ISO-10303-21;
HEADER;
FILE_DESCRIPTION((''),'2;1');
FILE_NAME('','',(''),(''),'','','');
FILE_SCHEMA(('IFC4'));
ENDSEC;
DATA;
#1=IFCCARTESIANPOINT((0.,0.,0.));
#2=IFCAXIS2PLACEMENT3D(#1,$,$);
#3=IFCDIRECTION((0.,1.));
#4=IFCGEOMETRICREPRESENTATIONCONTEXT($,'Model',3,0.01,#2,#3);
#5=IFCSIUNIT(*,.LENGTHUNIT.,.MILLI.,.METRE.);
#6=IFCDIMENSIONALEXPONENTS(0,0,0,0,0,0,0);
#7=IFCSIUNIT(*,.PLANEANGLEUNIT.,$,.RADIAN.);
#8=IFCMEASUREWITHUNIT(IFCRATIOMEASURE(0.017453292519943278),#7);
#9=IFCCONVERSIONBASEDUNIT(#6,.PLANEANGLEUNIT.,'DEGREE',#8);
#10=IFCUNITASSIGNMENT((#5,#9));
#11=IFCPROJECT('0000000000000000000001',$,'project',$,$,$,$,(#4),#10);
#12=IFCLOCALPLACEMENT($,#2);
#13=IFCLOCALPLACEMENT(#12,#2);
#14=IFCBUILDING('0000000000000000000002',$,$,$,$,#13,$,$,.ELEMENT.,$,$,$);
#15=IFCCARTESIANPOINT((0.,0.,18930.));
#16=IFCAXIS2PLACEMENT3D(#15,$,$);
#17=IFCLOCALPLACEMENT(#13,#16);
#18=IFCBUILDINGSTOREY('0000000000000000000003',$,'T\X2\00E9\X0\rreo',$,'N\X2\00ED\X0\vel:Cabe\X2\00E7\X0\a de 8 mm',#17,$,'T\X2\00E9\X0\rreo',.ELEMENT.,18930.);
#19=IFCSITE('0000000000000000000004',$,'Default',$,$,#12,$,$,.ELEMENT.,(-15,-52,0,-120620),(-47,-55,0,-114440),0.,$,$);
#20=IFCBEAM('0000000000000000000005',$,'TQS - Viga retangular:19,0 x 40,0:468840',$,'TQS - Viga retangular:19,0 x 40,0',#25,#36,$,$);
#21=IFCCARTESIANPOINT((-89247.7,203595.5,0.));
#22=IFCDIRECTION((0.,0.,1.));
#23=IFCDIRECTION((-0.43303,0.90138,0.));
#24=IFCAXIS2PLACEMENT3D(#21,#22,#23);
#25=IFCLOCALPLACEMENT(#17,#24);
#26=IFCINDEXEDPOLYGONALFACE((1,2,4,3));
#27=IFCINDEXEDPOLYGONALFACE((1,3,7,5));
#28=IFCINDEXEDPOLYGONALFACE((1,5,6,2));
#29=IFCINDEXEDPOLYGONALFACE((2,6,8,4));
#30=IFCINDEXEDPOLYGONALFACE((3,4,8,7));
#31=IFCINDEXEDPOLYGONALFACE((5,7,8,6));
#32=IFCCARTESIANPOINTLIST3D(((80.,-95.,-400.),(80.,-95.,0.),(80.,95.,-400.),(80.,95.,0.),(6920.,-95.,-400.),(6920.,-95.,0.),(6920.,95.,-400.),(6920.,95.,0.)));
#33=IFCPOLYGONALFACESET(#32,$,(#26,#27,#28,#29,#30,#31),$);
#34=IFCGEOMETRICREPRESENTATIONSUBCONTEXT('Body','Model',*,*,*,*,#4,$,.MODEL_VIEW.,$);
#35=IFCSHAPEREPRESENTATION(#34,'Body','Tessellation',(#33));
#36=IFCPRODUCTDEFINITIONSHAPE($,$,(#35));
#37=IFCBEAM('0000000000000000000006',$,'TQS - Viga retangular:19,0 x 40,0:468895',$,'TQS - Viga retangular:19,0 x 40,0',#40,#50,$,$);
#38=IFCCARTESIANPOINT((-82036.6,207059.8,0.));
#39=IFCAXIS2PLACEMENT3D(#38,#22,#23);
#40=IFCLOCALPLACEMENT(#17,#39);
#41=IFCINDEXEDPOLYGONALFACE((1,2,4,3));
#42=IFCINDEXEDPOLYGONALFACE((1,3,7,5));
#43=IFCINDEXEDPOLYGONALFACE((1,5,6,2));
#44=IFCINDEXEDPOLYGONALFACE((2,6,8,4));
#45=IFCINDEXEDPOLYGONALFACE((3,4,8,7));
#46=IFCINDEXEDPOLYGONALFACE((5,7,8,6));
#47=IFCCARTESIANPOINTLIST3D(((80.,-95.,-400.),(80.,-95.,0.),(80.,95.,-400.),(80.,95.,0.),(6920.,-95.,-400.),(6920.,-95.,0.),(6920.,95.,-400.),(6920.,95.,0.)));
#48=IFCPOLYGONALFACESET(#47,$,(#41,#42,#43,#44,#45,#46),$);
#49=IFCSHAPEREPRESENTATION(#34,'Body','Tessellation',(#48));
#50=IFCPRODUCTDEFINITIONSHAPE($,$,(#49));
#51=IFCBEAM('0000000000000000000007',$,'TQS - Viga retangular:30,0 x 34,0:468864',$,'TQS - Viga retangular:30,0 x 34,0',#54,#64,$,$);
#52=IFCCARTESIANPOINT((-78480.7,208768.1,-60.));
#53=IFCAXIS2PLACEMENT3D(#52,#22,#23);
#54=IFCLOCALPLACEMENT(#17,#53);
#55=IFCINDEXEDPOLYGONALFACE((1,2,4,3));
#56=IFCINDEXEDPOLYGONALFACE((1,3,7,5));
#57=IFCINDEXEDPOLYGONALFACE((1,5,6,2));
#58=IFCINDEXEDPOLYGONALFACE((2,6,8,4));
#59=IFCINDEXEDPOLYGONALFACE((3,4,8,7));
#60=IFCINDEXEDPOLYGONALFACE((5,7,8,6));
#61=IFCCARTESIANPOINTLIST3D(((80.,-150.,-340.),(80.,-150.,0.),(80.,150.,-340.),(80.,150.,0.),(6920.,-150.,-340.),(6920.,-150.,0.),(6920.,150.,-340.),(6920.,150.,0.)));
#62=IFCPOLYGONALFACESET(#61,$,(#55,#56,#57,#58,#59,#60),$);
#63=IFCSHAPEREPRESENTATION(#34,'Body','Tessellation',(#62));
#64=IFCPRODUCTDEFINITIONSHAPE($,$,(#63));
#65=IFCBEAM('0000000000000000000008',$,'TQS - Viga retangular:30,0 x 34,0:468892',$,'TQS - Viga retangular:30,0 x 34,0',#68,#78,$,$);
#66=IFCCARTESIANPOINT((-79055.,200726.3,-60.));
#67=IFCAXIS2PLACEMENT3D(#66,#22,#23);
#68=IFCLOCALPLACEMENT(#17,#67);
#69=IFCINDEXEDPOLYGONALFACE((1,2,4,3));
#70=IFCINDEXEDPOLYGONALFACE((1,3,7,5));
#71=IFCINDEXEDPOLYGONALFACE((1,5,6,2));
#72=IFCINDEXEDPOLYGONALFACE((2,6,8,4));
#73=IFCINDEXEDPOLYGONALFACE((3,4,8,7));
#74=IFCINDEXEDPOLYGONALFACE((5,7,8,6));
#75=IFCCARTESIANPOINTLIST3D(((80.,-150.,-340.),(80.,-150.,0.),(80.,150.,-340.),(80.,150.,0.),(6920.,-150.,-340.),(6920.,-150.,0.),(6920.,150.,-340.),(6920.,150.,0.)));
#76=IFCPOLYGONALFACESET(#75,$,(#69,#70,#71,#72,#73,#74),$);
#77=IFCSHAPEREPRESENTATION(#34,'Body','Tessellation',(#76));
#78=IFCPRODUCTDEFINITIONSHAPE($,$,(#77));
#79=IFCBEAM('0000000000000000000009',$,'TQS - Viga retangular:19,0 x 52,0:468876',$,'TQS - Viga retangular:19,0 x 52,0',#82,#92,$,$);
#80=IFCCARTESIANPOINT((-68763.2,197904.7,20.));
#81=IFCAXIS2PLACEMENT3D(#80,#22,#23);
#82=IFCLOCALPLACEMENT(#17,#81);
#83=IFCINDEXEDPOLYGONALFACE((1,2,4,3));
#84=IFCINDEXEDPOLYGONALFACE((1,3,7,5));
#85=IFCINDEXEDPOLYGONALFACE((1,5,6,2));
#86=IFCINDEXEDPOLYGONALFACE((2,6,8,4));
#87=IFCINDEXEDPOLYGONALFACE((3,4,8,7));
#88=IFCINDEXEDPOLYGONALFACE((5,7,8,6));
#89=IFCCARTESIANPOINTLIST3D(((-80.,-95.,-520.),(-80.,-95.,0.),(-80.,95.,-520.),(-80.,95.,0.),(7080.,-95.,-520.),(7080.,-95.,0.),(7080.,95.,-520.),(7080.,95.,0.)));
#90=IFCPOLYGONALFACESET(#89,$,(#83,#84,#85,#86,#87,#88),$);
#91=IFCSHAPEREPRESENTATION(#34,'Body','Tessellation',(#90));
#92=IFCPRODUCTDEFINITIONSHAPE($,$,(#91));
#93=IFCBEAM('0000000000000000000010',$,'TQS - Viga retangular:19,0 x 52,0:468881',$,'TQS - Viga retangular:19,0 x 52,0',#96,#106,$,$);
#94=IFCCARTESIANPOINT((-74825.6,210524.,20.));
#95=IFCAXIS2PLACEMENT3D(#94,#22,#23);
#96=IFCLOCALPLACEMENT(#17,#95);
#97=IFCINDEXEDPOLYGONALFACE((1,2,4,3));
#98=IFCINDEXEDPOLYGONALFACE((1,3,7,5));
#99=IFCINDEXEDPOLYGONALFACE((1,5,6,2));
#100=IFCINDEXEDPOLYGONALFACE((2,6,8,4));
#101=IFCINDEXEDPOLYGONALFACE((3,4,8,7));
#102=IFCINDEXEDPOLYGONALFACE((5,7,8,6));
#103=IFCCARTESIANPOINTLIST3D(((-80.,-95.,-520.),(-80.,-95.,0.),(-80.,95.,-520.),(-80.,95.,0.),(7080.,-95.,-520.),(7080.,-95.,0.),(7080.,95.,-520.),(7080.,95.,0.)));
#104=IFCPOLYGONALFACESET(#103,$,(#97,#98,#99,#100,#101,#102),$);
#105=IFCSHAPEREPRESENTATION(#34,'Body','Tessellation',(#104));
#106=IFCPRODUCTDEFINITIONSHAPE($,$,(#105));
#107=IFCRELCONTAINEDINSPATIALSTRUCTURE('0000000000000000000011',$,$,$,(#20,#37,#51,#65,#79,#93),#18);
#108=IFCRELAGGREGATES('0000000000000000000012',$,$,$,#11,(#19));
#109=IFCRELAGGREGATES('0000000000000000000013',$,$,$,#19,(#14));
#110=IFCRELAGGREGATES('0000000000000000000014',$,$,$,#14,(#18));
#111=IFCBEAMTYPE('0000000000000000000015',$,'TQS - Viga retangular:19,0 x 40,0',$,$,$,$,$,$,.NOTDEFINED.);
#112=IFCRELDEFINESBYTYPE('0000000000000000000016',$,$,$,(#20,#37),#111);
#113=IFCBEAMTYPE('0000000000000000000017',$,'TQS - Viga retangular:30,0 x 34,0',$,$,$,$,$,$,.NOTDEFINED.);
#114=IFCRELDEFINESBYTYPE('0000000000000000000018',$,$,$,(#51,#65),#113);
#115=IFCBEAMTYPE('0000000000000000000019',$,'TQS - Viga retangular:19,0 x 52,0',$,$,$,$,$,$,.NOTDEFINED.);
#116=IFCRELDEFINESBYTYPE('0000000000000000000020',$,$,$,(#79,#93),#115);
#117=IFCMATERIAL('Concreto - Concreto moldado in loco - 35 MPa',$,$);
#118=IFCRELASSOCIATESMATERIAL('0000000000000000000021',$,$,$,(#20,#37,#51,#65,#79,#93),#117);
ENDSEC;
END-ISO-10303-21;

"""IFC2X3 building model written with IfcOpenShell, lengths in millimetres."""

from ifc_helpers import new_model, entity, si_unit, converted_unit, direction, frame, frame_2d, origin, origin_2d_with_axis, place, context, subcontext, project, spatial, rectangle, extrude, material, type_object, element, save


model = new_model("IFC2X3")

# Units and contexts
model_context = context("Model", 3, precision=0.01, world=origin(), true_north=direction((0.0, 1.0)))
body_context = subcontext(model_context, "Body", "Model", "MODEL_VIEW")
ifc_project = project(units=[si_unit("LENGTHUNIT", "METRE", prefix="MILLI"), converted_unit("PLANEANGLEUNIT", "DEGREE", entity("IfcRatioMeasure", 0.017453292519943278), si_unit("PLANEANGLEUNIT", "RADIAN"), dimensions=[0, 0, 0, 0, 0, 0, 0])], contexts=[model_context])

# Site, building, storey
site_placement = place(None, origin())
site = spatial("IfcSite", under=ifc_project, at=site_placement, Name="Default", CompositionType="ELEMENT", RefLatitude=(-15, -52, 0, -120620), RefLongitude=(-47, -55, 0, -114440), RefElevation=0.0)
building_placement = place(site_placement, origin())
building = spatial("IfcBuilding", under=site, at=building_placement, CompositionType="ELEMENT")
storey_placement = place(building_placement, frame((0.0, 0.0, 18930.0)))
storey = spatial("IfcBuildingStorey", under=building, at=storey_placement, Name="Térreo", ObjectType="Nível:Cabeça de 8 mm", LongName="Térreo", CompositionType="ELEMENT", Elevation=18930.0)

# Beams
ifc_material_1 = material(Name="Concreto - Concreto moldado in loco - 35 MPa")
beam_type_1 = type_object("IfcBeamType", Name="TQS - Viga retangular:19,0 x 40,0", PredefinedType="NOTDEFINED")
beam_1_placement = place(storey_placement, frame((-89247.7, 203595.5, 0.0), z_axis=(0.0, 0.0, 1.0), x_axis=(-0.43303, 0.90138, 0.0)))
element("IfcBeam", 1, at=beam_1_placement, inside=storey, type_object=beam_type_1, material=ifc_material_1, Name="TQS - Viga retangular:19,0 x 40,0:468840", ObjectType="TQS - Viga retangular:19,0 x 40,0", context=body_context, shape_type="SweptSolid", body=[
    extrude(rectangle(XDim=400.0, YDim=190.0, at=origin_2d_with_axis()), frame((80.0, 0.0, -200.0), z_axis=(1.0, 0.0, 0.0), x_axis=(0.0, 0.0, -1.0)), (0.0, 0.0, 1.0), 6840.0),
])
beam_2_placement = place(storey_placement, frame((-82036.6, 207059.8, 0.0), z_axis=(0.0, 0.0, 1.0), x_axis=(-0.43303, 0.90138, 0.0)))
element("IfcBeam", 2, at=beam_2_placement, inside=storey, type_object=beam_type_1, material=ifc_material_1, Name="TQS - Viga retangular:19,0 x 40,0:468895", ObjectType="TQS - Viga retangular:19,0 x 40,0", context=body_context, shape_type="SweptSolid", body=[
    extrude(rectangle(XDim=400.0, YDim=190.0, at=origin_2d_with_axis()), frame((80.0, 0.0, -200.0), z_axis=(1.0, 0.0, 0.0), x_axis=(0.0, 0.0, -1.0)), (0.0, 0.0, 1.0), 6840.0),
])
beam_type_2 = type_object("IfcBeamType", Name="TQS - Viga retangular:30,0 x 34,0", PredefinedType="NOTDEFINED")
beam_3_placement = place(storey_placement, frame((-78480.7, 208768.1, -60.0), z_axis=(0.0, 0.0, 1.0), x_axis=(-0.43303, 0.90138, 0.0)))
element("IfcBeam", 3, at=beam_3_placement, inside=storey, type_object=beam_type_2, material=ifc_material_1, Name="TQS - Viga retangular:30,0 x 34,0:468864", ObjectType="TQS - Viga retangular:30,0 x 34,0", context=body_context, shape_type="SweptSolid", body=[
    extrude(rectangle(XDim=340.0, YDim=300.0, at=frame_2d((0.0, 0.0), x_axis=(1.0, 0.0))), frame((80.0, 0.0, -170.0), z_axis=(1.0, 0.0, 0.0), x_axis=(0.0, 0.0, -1.0)), (0.0, 0.0, 1.0), 6840.0),
])
beam_4_placement = place(storey_placement, frame((-79055.0, 200726.3, -60.0), z_axis=(0.0, 0.0, 1.0), x_axis=(-0.43303, 0.90138, 0.0)))
element("IfcBeam", 4, at=beam_4_placement, inside=storey, type_object=beam_type_2, material=ifc_material_1, Name="TQS - Viga retangular:30,0 x 34,0:468892", ObjectType="TQS - Viga retangular:30,0 x 34,0", context=body_context, shape_type="SweptSolid", body=[
    extrude(rectangle(XDim=340.0, YDim=300.0, at=frame_2d((0.0, 0.0), x_axis=(1.0, 0.0))), frame((80.0, 0.0, -170.0), z_axis=(1.0, 0.0, 0.0), x_axis=(0.0, 0.0, -1.0)), (0.0, 0.0, 1.0), 6840.0),
])
beam_type_3 = type_object("IfcBeamType", Name="TQS - Viga retangular:19,0 x 52,0", PredefinedType="NOTDEFINED")
beam_5_placement = place(storey_placement, frame((-68763.2, 197904.7, 20.0), z_axis=(0.0, 0.0, 1.0), x_axis=(-0.43303, 0.90138, 0.0)))
element("IfcBeam", 5, at=beam_5_placement, inside=storey, type_object=beam_type_3, material=ifc_material_1, Name="TQS - Viga retangular:19,0 x 52,0:468876", ObjectType="TQS - Viga retangular:19,0 x 52,0", context=body_context, shape_type="SweptSolid", body=[
    extrude(rectangle(XDim=520.0, YDim=190.0, at=frame_2d((0.0, 0.0), x_axis=(1.0, 0.0))), frame((-80.0, 0.0, -260.0), z_axis=(1.0, 0.0, 0.0), x_axis=(0.0, 0.0, -1.0)), (0.0, 0.0, 1.0), 7160.0),
])
beam_6_placement = place(storey_placement, frame((-74825.6, 210524.0, 20.0), z_axis=(0.0, 0.0, 1.0), x_axis=(-0.43303, 0.90138, 0.0)))
element("IfcBeam", 6, at=beam_6_placement, inside=storey, type_object=beam_type_3, material=ifc_material_1, Name="TQS - Viga retangular:19,0 x 52,0:468881", ObjectType="TQS - Viga retangular:19,0 x 52,0", context=body_context, shape_type="SweptSolid", body=[
    extrude(rectangle(XDim=520.0, YDim=190.0, at=frame_2d((0.0, 0.0), x_axis=(1.0, 0.0))), frame((-80.0, 0.0, -260.0), z_axis=(1.0, 0.0, 0.0), x_axis=(0.0, 0.0, -1.0)), (0.0, 0.0, 1.0), 7160.0),
])

save(model, "model.ifc")
